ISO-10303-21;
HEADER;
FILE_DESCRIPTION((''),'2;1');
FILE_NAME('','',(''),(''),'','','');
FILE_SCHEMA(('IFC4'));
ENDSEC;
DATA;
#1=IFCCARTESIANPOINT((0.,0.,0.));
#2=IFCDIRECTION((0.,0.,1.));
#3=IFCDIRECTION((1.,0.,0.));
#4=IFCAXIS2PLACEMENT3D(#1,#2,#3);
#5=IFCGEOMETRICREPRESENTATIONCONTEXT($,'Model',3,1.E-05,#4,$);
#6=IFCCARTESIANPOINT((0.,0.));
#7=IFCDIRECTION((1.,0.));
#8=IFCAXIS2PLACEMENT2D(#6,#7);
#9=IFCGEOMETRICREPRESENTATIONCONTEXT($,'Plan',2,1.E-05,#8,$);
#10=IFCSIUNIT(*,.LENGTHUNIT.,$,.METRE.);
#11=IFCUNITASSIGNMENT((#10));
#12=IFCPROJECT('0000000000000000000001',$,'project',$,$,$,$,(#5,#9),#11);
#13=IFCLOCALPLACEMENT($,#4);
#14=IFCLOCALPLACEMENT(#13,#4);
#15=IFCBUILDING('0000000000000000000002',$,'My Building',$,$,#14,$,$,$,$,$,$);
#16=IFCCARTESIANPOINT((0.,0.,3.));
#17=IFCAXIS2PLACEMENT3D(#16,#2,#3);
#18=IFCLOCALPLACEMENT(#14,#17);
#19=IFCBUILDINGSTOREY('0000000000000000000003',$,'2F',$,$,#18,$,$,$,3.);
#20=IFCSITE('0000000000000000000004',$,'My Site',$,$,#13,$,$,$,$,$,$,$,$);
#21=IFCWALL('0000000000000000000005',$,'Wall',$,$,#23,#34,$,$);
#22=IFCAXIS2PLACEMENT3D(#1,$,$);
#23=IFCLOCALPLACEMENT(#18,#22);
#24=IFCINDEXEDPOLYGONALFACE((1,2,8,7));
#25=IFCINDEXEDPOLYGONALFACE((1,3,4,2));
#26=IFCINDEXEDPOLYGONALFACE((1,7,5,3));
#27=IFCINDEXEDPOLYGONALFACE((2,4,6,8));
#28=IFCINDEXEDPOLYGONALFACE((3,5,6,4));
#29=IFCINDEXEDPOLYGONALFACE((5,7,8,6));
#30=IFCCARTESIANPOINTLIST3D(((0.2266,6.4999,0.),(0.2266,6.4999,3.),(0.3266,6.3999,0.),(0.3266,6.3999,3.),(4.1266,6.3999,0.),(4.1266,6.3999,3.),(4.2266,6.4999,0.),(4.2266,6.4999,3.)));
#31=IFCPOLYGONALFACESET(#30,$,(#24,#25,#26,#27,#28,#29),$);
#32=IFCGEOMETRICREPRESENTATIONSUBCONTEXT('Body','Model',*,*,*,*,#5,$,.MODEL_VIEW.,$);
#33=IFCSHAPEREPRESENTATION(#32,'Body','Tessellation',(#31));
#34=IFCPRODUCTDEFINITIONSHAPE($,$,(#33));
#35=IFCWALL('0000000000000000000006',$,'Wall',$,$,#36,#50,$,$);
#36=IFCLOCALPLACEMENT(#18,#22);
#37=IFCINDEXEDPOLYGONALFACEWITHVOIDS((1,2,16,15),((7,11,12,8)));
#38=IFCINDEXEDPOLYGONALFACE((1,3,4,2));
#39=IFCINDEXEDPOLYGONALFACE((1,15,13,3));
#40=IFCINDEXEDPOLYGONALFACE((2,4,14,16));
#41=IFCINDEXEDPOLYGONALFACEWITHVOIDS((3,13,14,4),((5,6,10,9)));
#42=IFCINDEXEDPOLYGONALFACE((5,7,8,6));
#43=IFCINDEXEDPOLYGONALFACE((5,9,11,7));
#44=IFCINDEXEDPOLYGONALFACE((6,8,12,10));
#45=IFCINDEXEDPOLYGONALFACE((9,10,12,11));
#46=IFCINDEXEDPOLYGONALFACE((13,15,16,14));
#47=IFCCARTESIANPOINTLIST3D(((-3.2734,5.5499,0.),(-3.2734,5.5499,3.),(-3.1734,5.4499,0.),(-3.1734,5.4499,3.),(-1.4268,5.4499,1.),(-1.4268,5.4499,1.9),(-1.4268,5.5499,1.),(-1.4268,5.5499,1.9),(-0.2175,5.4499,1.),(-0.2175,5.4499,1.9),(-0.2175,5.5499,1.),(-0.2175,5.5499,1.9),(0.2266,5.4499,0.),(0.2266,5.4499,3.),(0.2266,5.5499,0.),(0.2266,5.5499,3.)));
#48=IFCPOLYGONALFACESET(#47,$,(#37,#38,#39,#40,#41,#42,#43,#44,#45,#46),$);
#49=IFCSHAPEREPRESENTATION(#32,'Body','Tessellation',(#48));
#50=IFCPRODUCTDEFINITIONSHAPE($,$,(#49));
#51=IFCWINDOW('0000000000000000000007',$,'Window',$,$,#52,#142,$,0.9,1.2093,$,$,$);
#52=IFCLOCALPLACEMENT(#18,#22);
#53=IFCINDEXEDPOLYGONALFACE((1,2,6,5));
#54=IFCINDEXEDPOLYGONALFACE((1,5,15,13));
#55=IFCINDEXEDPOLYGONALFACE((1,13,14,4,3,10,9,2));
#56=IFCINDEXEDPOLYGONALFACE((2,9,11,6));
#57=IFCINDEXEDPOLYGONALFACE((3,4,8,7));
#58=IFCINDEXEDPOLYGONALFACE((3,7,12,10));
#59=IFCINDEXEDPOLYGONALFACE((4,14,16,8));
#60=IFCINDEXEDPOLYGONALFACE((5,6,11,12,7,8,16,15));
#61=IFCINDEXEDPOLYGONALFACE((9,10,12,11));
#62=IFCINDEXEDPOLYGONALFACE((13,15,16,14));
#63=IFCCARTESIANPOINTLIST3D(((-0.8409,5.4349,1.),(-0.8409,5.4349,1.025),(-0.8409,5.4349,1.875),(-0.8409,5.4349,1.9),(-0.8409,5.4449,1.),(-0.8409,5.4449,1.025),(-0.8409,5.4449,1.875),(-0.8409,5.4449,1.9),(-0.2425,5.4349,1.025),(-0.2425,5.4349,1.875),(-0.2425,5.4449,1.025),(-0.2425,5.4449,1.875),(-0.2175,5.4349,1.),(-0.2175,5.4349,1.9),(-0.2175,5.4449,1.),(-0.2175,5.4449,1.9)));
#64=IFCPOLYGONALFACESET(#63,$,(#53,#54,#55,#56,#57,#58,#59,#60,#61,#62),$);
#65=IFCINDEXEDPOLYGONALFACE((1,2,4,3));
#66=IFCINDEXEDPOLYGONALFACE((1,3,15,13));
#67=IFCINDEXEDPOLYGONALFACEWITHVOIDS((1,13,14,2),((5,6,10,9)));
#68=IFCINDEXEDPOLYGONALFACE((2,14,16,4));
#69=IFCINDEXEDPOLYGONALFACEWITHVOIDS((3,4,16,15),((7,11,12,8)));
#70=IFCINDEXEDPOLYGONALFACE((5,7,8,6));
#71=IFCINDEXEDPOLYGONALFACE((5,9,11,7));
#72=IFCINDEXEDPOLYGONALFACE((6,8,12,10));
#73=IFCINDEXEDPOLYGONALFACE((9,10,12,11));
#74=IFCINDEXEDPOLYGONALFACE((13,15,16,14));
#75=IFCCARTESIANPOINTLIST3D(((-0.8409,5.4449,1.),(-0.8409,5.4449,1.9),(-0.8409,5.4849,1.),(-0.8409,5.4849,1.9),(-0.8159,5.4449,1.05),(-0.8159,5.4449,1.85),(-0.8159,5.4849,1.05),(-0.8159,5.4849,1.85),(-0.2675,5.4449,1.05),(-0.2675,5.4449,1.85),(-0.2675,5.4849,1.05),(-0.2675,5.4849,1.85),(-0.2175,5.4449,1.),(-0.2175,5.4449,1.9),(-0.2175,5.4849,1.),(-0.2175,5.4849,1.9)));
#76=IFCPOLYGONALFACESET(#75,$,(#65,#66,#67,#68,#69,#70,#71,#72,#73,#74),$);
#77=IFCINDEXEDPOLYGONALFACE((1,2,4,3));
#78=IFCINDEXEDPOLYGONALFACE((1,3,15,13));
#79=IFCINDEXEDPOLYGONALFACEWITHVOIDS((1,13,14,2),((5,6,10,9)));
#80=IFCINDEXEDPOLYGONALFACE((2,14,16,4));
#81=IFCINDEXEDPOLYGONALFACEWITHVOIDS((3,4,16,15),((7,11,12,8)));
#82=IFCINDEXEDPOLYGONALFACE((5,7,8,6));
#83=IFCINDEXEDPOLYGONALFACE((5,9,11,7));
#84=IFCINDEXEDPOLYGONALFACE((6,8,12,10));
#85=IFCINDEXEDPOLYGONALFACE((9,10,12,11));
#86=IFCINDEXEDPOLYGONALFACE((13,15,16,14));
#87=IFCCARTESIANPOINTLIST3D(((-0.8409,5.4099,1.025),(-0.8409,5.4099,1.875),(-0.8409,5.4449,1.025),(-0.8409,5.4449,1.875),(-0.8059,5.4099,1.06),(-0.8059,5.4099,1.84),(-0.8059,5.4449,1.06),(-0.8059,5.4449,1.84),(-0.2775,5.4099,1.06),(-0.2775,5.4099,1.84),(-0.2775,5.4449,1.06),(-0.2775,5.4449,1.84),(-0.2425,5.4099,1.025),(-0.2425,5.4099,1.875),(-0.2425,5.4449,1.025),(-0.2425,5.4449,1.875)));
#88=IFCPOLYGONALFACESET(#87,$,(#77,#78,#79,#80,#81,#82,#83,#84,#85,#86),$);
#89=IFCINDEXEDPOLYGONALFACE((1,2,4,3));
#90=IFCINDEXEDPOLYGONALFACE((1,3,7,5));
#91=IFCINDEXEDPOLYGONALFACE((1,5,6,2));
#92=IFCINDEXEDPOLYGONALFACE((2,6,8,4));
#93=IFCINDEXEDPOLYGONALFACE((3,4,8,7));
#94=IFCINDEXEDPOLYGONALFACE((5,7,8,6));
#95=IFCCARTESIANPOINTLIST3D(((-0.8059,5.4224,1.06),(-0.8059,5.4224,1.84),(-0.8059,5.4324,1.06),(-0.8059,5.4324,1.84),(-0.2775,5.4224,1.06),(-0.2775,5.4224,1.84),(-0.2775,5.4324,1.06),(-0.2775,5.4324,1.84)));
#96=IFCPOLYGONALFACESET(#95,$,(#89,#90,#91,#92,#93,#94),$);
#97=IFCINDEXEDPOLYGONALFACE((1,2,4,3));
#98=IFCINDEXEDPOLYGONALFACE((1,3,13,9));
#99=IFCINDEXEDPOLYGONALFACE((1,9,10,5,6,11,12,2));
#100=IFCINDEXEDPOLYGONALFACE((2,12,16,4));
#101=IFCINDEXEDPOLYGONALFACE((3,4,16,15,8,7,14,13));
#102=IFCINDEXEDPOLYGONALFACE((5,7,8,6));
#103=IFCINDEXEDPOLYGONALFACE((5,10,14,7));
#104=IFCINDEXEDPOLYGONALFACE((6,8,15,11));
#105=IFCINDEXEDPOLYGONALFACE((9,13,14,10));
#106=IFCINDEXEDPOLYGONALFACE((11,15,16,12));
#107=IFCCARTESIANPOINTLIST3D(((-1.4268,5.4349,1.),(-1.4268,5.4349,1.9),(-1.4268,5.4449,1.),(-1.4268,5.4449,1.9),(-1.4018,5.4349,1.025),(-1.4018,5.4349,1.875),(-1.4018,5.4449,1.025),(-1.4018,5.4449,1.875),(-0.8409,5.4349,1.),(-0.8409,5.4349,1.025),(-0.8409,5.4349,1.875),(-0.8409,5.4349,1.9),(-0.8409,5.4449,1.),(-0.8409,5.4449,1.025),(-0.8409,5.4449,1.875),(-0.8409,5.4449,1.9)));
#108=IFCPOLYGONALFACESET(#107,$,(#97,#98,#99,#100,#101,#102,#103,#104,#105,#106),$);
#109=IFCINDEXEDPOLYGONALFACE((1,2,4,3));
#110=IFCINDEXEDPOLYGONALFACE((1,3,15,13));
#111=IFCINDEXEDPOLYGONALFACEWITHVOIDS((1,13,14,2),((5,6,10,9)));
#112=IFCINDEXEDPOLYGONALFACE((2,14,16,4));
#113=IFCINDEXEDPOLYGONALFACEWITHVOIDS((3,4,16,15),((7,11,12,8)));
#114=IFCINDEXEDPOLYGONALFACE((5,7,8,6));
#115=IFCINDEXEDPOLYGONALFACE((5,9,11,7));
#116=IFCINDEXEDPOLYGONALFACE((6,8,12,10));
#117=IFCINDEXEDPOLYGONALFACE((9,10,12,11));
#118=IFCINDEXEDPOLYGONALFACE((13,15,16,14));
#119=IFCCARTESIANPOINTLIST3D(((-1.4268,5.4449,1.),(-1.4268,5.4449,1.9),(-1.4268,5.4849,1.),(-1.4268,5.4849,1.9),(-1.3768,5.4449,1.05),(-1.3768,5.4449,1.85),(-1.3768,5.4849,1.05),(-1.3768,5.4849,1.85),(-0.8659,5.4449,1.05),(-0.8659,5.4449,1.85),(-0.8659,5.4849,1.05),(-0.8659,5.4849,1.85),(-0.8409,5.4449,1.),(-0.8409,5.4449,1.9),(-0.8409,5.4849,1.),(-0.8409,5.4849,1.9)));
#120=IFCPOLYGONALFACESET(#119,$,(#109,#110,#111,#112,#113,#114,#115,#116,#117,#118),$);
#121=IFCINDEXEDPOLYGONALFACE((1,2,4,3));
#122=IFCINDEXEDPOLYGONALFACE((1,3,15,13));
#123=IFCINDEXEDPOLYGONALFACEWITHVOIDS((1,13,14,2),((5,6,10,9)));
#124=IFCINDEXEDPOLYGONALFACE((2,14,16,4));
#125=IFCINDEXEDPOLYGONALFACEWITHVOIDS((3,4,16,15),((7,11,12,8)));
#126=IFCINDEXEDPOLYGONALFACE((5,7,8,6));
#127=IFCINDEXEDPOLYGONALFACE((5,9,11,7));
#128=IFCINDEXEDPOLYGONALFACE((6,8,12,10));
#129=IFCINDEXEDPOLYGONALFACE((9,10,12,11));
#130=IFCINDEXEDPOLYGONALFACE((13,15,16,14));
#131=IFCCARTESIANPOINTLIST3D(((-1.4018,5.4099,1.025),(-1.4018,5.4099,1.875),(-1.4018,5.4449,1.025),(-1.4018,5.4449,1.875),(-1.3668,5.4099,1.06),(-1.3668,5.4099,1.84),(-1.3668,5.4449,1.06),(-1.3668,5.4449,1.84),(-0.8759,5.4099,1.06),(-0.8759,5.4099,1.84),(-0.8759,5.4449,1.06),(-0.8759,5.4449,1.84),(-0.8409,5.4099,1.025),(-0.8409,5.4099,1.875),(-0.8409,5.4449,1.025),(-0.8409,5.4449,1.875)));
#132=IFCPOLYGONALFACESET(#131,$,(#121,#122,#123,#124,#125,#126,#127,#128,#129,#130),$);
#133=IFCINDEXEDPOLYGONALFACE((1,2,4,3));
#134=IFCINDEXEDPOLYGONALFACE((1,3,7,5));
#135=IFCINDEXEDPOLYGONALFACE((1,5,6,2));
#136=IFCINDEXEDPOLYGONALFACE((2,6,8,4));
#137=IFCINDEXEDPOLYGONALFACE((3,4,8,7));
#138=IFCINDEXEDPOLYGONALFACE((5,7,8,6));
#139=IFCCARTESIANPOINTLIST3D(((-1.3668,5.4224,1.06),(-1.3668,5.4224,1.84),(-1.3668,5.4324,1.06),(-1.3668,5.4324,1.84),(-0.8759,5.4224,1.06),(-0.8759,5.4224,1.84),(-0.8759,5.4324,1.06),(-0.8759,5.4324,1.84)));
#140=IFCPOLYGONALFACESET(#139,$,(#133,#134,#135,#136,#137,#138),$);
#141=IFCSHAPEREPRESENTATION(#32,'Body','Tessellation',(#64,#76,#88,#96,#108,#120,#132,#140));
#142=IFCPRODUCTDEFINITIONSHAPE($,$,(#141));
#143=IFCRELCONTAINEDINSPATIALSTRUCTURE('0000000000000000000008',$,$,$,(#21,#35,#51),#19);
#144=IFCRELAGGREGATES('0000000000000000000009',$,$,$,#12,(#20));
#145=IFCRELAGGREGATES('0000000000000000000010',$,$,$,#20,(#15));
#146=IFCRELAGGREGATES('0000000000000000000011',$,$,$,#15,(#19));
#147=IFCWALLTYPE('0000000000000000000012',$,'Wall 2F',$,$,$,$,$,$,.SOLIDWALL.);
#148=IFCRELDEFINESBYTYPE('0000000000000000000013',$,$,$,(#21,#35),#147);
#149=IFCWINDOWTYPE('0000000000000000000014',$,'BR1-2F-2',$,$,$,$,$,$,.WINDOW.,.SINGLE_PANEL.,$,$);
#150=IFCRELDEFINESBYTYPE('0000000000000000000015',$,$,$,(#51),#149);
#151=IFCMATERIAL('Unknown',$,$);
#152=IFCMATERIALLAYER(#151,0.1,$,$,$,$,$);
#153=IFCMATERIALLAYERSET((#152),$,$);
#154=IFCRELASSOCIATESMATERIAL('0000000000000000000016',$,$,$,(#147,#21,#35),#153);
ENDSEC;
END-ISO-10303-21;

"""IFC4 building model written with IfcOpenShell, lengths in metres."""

from ifc_helpers import new_model, entity, si_unit, frame, origin_with_axes, origin_2d_with_axis, place, context, subcontext, project, spatial, polyline, line, indexed_curve, outline, extrude, shape, source, transform, mapped, material, layer, layer_set, layer_usage, type_object, type_shapes, element, fill, save


model = new_model("IFC4")

# Units and contexts
model_context = context("Model", 3, precision=1e-05, world=origin_with_axes())
plan_context = context("Plan", 2, precision=1e-05, world=origin_2d_with_axis())
body_context_1 = subcontext(model_context, "Body", "Model", "MODEL_VIEW")
body_context_2 = subcontext(plan_context, "Body", "Plan", "PLAN_VIEW")
ifc_project = project(units=[si_unit("LENGTHUNIT", "METRE")], contexts=[model_context, plan_context])

# Site, building, storey
site_placement = place(None, origin_with_axes())
site = spatial("IfcSite", under=ifc_project, at=site_placement, Name="My Site")
building_placement = place(site_placement, origin_with_axes())
building = spatial("IfcBuilding", under=site, at=building_placement, Name="My Building")
storey_placement = place(building_placement, frame((0.0, 0.0, 3.0), z_axis=(0.0, 0.0, 1.0), x_axis=(1.0, 0.0, 0.0)))
storey = spatial("IfcBuildingStorey", under=building, at=storey_placement, Name="2F", Elevation=3.0)

# Shared definitions
ifc_material = material(Name="Unknown")

# Shared definitions
ifc_layer_1 = layer(ifc_material, 0.1)
ifc_layer_set_1 = layer_set([ifc_layer_1])
wall_type = type_object("IfcWallType", Name="Wall 2F", PredefinedType="SOLIDWALL", material=ifc_layer_set_1)

# Wall
ifc_layer_usage_1 = layer_usage(ifc_layer_set_1, "AXIS2", "POSITIVE", 0.0)
wall_1_placement = place(storey_placement, frame((4.2266, 6.4999, 0.0), z_axis=(0.0, 0.0, 1.0), x_axis=(-1.0, 0.0, 0.0)))
element("IfcWall", 1, at=wall_1_placement, inside=storey, type_object=wall_type, material=ifc_layer_usage_1, Name="Wall", context=body_context_1, shape_type="SweptSolid", body=[
    extrude(outline(polyline([(0.0, 0.0), (4.0, 0.0), (3.9, 0.1), (0.1, 0.1), (0.0, 0.0)])), origin_with_axes(), (0.0, 0.0, 1.0), 3.0),
])

# Wall, opening, window
ifc_layer_usage_2 = layer_usage(ifc_layer_set_1, "AXIS2", "POSITIVE", 0.0)
wall_2_placement = place(storey_placement, frame((0.2266, 5.5499, 0.0), z_axis=(0.0, 0.0, 1.0), x_axis=(-1.0, 0.0, 0.0)))
wall_2 = element("IfcWall", 2, at=wall_2_placement, inside=storey, type_object=wall_type, material=ifc_layer_usage_2, Name="Wall", context=body_context_1, shape_type="SweptSolid", body=[
    extrude(outline(polyline([(0.0, 0.0), (3.5, 0.0), (3.4, 0.1), (0.0, 0.1), (0.0, 0.0)])), origin_with_axes(), (0.0, 0.0, 1.0), 3.0),
])
opening_1_placement = place(wall_2_placement, frame((0.4441, 0.015, 1.0), z_axis=(0.0, 0.0, 1.0), x_axis=(1.0, 0.0, 0.0)))
opening_1 = element("IfcOpeningElement", 3, at=opening_1_placement, cuts=wall_2, PredefinedType="OPENING", context=body_context_1, shape_type="SweptSolid", body=[
    extrude(outline(polyline([(0.0, 0.0), (1.2093, 0.0), (1.2093, 0.9), (0.0, 0.9), (0.0, 0.0)])), frame((0.0, -0.6, 0.0), z_axis=(0.0, -1.0, 0.0), x_axis=(1.0, 0.0, 0.0)), (0.0, 0.0, -1.0), 1.2),
])
window_type_1 = type_object("IfcWindowType", Name="BR1-2F-2", PartitioningType="SINGLE_PANEL", PredefinedType="WINDOW")
shared_shape_1 = source(origin_with_axes(), body_context_1, "Body", "SweptSolid", [
    extrude(outline(indexed_curve([(0.6234, 0.0), (0.0, 0.0), (0.0, 0.9), (0.6234, 0.9), (0.6234, 0.875), (0.025, 0.875), (0.025, 0.025), (0.6234, 0.025)], segments=[line(1, 2, 3, 4, 5, 6, 7, 8, 1)])), frame((0.0, 0.09, 0.0), z_axis=(0.0, -1.0, 0.0), x_axis=(1.0, 0.0, 0.0)), (0.0, 0.0, -1.0), 0.01),
    extrude(outline(indexed_curve([(0.0, 0.0), (0.6234, 0.0), (0.6234, 0.9), (0.0, 0.9)], segments=[line(1, 2, 3, 4, 1)]), holes=[indexed_curve([(0.05, 0.05), (0.5984, 0.05), (0.5984, 0.85), (0.05, 0.85)], segments=[line(1, 2, 3, 4, 1)])]), frame((0.0, 0.05, 0.0), z_axis=(0.0, -1.0, 0.0), x_axis=(1.0, 0.0, 0.0)), (0.0, 0.0, -1.0), 0.04),
    extrude(outline(indexed_curve([(0.0, 0.0), (0.5984, 0.0), (0.5984, 0.85), (0.0, 0.85)], segments=[line(1, 2, 3, 4, 1)]), holes=[indexed_curve([(0.035, 0.035), (0.5634, 0.035), (0.5634, 0.815), (0.035, 0.815)], segments=[line(1, 2, 3, 4, 1)])]), frame((0.025, 0.09, 0.025), z_axis=(0.0, -1.0, 0.0), x_axis=(1.0, 0.0, 0.0)), (0.0, 0.0, -1.0), 0.035),
    extrude(outline(indexed_curve([(0.035, 0.035), (0.5634, 0.035), (0.5634, 0.815), (0.035, 0.815)], segments=[line(1, 2, 3, 4, 1)])), frame((0.025, 0.1025, 0.025), z_axis=(0.0, -1.0, 0.0), x_axis=(1.0, 0.0, 0.0)), (0.0, 0.0, -1.0), 0.01),
    extrude(outline(indexed_curve([(0.0, 0.9), (0.5859, 0.9), (0.5859, 0.0), (0.0, 0.0), (0.0, 0.025), (0.5609, 0.025), (0.5609, 0.875), (0.0, 0.875)], segments=[line(1, 2, 3, 4, 5, 6, 7, 8, 1)])), frame((0.6234, 0.09, 0.0), z_axis=(0.0, -1.0, 0.0), x_axis=(1.0, 0.0, 0.0)), (0.0, 0.0, -1.0), 0.01),
    extrude(outline(indexed_curve([(0.0, 0.0), (0.5859, 0.0), (0.5859, 0.9), (0.0, 0.9)], segments=[line(1, 2, 3, 4, 1)]), holes=[indexed_curve([(0.025, 0.05), (0.5359, 0.05), (0.5359, 0.85), (0.025, 0.85)], segments=[line(1, 2, 3, 4, 1)])]), frame((0.6234, 0.05, 0.0), z_axis=(0.0, -1.0, 0.0), x_axis=(1.0, 0.0, 0.0)), (0.0, 0.0, -1.0), 0.04),
    extrude(outline(indexed_curve([(0.0, 0.0), (0.5609, 0.0), (0.5609, 0.85), (0.0, 0.85)], segments=[line(1, 2, 3, 4, 1)]), holes=[indexed_curve([(0.035, 0.035), (0.5259, 0.035), (0.5259, 0.815), (0.035, 0.815)], segments=[line(1, 2, 3, 4, 1)])]), frame((0.6234, 0.09, 0.025), z_axis=(0.0, -1.0, 0.0), x_axis=(1.0, 0.0, 0.0)), (0.0, 0.0, -1.0), 0.035),
    extrude(outline(indexed_curve([(0.035, 0.035), (0.5259, 0.035), (0.5259, 0.815), (0.035, 0.815)], segments=[line(1, 2, 3, 4, 1)])), frame((0.6234, 0.1025, 0.025), z_axis=(0.0, -1.0, 0.0), x_axis=(1.0, 0.0, 0.0)), (0.0, 0.0, -1.0), 0.01),
])
shared_shape_2 = source(origin_with_axes(), body_context_2, "Body", "Curve2D", [
    entity("IfcIndexedPolyCurve", entity("IfcCartesianPointList2D", [[0.05, 0.05], [0.5984, 0.05]])),
    entity("IfcIndexedPolyCurve", entity("IfcCartesianPointList2D", [[0.0, 0.1], [0.025, 0.1], [0.025, 0.09], [0.05, 0.09], [0.05, 0.05], [0.0, 0.05]]), [entity("IfcLineIndex", [1, 2, 3, 4, 5, 6, 1])]),
    entity("IfcIndexedPolyCurve", entity("IfcCartesianPointList2D", [[0.6234, 0.1], [0.6234, 0.1], [0.6234, 0.09], [0.5984, 0.09], [0.5984, 0.05], [0.6234, 0.05]])),
    entity("IfcIndexedPolyCurve", entity("IfcCartesianPointList2D", [[0.025, 0.09], [0.06, 0.09], [0.06, 0.125], [0.025, 0.125]]), [entity("IfcLineIndex", [1, 2, 3, 4, 1])]),
    entity("IfcIndexedPolyCurve", entity("IfcCartesianPointList2D", [[0.6234, 0.09], [0.5884, 0.09], [0.5884, 0.125], [0.6234, 0.125]]), [entity("IfcLineIndex", [1, 2, 3, 4, 1])]),
    entity("IfcIndexedPolyCurve", entity("IfcCartesianPointList2D", [[0.06, 0.09], [0.5884, 0.09]])),
    entity("IfcIndexedPolyCurve", entity("IfcCartesianPointList2D", [[0.06, 0.125], [0.5884, 0.125]])),
    entity("IfcIndexedPolyCurve", entity("IfcCartesianPointList2D", [[0.06, 0.1075], [0.5884, 0.1075]])),
    entity("IfcIndexedPolyCurve", entity("IfcCartesianPointList2D", [[0.6484, 0.05], [1.1593, 0.05]])),
    entity("IfcIndexedPolyCurve", entity("IfcCartesianPointList2D", [[0.6234, 0.1], [0.6234, 0.1], [0.6234, 0.09], [0.6484, 0.09], [0.6484, 0.05], [0.6234, 0.05]])),
    entity("IfcIndexedPolyCurve", entity("IfcCartesianPointList2D", [[1.2093, 0.1], [1.1843, 0.1], [1.1843, 0.09], [1.1593, 0.09], [1.1593, 0.05], [1.2093, 0.05]]), [entity("IfcLineIndex", [1, 2, 3, 4, 5, 6, 1])]),
    entity("IfcIndexedPolyCurve", entity("IfcCartesianPointList2D", [[0.6234, 0.09], [0.6584, 0.09], [0.6584, 0.125], [0.6234, 0.125]]), [entity("IfcLineIndex", [1, 2, 3, 4, 1])]),
    entity("IfcIndexedPolyCurve", entity("IfcCartesianPointList2D", [[1.1843, 0.09], [1.1493, 0.09], [1.1493, 0.125], [1.1843, 0.125]]), [entity("IfcLineIndex", [1, 2, 3, 4, 1])]),
    entity("IfcIndexedPolyCurve", entity("IfcCartesianPointList2D", [[0.6584, 0.09], [1.1493, 0.09]])),
    entity("IfcIndexedPolyCurve", entity("IfcCartesianPointList2D", [[0.6584, 0.125], [1.1493, 0.125]])),
    entity("IfcIndexedPolyCurve", entity("IfcCartesianPointList2D", [[0.6584, 0.1075], [1.1493, 0.1075]])),
])
type_shapes(window_type_1, [shared_shape_1, shared_shape_2])
window_1_placement = place(storey_placement, frame((-0.2175, 5.5349, 1.0), z_axis=(0.0, 0.0, 1.0), x_axis=(-1.0, 0.0, 0.0)))
window_1 = element("IfcWindow", 4, at=window_1_placement, inside=storey, type_object=window_type_1, Name="Window", OverallHeight=0.9, OverallWidth=1.2093, shapes=[
    shape(body_context_1, "Body", "MappedRepresentation", [mapped(shared_shape_1, transform((0.0, 0.0, 0.0), x_axis=(1.0, 0.0, 0.0), y_axis=(0.0, 1.0, 0.0), z_axis=(0.0, 0.0, 1.0), scale=1.0))]),
    shape(body_context_2, "Body", "MappedRepresentation", [mapped(shared_shape_2, transform((0.0, 0.0, 0.0), x_axis=(1.0, 0.0, 0.0), y_axis=(0.0, 1.0, 0.0), z_axis=(0.0, 0.0, 1.0), scale=1.0))]),
])
fill(opening_1, window_1)

save(model, "model.ifc")
